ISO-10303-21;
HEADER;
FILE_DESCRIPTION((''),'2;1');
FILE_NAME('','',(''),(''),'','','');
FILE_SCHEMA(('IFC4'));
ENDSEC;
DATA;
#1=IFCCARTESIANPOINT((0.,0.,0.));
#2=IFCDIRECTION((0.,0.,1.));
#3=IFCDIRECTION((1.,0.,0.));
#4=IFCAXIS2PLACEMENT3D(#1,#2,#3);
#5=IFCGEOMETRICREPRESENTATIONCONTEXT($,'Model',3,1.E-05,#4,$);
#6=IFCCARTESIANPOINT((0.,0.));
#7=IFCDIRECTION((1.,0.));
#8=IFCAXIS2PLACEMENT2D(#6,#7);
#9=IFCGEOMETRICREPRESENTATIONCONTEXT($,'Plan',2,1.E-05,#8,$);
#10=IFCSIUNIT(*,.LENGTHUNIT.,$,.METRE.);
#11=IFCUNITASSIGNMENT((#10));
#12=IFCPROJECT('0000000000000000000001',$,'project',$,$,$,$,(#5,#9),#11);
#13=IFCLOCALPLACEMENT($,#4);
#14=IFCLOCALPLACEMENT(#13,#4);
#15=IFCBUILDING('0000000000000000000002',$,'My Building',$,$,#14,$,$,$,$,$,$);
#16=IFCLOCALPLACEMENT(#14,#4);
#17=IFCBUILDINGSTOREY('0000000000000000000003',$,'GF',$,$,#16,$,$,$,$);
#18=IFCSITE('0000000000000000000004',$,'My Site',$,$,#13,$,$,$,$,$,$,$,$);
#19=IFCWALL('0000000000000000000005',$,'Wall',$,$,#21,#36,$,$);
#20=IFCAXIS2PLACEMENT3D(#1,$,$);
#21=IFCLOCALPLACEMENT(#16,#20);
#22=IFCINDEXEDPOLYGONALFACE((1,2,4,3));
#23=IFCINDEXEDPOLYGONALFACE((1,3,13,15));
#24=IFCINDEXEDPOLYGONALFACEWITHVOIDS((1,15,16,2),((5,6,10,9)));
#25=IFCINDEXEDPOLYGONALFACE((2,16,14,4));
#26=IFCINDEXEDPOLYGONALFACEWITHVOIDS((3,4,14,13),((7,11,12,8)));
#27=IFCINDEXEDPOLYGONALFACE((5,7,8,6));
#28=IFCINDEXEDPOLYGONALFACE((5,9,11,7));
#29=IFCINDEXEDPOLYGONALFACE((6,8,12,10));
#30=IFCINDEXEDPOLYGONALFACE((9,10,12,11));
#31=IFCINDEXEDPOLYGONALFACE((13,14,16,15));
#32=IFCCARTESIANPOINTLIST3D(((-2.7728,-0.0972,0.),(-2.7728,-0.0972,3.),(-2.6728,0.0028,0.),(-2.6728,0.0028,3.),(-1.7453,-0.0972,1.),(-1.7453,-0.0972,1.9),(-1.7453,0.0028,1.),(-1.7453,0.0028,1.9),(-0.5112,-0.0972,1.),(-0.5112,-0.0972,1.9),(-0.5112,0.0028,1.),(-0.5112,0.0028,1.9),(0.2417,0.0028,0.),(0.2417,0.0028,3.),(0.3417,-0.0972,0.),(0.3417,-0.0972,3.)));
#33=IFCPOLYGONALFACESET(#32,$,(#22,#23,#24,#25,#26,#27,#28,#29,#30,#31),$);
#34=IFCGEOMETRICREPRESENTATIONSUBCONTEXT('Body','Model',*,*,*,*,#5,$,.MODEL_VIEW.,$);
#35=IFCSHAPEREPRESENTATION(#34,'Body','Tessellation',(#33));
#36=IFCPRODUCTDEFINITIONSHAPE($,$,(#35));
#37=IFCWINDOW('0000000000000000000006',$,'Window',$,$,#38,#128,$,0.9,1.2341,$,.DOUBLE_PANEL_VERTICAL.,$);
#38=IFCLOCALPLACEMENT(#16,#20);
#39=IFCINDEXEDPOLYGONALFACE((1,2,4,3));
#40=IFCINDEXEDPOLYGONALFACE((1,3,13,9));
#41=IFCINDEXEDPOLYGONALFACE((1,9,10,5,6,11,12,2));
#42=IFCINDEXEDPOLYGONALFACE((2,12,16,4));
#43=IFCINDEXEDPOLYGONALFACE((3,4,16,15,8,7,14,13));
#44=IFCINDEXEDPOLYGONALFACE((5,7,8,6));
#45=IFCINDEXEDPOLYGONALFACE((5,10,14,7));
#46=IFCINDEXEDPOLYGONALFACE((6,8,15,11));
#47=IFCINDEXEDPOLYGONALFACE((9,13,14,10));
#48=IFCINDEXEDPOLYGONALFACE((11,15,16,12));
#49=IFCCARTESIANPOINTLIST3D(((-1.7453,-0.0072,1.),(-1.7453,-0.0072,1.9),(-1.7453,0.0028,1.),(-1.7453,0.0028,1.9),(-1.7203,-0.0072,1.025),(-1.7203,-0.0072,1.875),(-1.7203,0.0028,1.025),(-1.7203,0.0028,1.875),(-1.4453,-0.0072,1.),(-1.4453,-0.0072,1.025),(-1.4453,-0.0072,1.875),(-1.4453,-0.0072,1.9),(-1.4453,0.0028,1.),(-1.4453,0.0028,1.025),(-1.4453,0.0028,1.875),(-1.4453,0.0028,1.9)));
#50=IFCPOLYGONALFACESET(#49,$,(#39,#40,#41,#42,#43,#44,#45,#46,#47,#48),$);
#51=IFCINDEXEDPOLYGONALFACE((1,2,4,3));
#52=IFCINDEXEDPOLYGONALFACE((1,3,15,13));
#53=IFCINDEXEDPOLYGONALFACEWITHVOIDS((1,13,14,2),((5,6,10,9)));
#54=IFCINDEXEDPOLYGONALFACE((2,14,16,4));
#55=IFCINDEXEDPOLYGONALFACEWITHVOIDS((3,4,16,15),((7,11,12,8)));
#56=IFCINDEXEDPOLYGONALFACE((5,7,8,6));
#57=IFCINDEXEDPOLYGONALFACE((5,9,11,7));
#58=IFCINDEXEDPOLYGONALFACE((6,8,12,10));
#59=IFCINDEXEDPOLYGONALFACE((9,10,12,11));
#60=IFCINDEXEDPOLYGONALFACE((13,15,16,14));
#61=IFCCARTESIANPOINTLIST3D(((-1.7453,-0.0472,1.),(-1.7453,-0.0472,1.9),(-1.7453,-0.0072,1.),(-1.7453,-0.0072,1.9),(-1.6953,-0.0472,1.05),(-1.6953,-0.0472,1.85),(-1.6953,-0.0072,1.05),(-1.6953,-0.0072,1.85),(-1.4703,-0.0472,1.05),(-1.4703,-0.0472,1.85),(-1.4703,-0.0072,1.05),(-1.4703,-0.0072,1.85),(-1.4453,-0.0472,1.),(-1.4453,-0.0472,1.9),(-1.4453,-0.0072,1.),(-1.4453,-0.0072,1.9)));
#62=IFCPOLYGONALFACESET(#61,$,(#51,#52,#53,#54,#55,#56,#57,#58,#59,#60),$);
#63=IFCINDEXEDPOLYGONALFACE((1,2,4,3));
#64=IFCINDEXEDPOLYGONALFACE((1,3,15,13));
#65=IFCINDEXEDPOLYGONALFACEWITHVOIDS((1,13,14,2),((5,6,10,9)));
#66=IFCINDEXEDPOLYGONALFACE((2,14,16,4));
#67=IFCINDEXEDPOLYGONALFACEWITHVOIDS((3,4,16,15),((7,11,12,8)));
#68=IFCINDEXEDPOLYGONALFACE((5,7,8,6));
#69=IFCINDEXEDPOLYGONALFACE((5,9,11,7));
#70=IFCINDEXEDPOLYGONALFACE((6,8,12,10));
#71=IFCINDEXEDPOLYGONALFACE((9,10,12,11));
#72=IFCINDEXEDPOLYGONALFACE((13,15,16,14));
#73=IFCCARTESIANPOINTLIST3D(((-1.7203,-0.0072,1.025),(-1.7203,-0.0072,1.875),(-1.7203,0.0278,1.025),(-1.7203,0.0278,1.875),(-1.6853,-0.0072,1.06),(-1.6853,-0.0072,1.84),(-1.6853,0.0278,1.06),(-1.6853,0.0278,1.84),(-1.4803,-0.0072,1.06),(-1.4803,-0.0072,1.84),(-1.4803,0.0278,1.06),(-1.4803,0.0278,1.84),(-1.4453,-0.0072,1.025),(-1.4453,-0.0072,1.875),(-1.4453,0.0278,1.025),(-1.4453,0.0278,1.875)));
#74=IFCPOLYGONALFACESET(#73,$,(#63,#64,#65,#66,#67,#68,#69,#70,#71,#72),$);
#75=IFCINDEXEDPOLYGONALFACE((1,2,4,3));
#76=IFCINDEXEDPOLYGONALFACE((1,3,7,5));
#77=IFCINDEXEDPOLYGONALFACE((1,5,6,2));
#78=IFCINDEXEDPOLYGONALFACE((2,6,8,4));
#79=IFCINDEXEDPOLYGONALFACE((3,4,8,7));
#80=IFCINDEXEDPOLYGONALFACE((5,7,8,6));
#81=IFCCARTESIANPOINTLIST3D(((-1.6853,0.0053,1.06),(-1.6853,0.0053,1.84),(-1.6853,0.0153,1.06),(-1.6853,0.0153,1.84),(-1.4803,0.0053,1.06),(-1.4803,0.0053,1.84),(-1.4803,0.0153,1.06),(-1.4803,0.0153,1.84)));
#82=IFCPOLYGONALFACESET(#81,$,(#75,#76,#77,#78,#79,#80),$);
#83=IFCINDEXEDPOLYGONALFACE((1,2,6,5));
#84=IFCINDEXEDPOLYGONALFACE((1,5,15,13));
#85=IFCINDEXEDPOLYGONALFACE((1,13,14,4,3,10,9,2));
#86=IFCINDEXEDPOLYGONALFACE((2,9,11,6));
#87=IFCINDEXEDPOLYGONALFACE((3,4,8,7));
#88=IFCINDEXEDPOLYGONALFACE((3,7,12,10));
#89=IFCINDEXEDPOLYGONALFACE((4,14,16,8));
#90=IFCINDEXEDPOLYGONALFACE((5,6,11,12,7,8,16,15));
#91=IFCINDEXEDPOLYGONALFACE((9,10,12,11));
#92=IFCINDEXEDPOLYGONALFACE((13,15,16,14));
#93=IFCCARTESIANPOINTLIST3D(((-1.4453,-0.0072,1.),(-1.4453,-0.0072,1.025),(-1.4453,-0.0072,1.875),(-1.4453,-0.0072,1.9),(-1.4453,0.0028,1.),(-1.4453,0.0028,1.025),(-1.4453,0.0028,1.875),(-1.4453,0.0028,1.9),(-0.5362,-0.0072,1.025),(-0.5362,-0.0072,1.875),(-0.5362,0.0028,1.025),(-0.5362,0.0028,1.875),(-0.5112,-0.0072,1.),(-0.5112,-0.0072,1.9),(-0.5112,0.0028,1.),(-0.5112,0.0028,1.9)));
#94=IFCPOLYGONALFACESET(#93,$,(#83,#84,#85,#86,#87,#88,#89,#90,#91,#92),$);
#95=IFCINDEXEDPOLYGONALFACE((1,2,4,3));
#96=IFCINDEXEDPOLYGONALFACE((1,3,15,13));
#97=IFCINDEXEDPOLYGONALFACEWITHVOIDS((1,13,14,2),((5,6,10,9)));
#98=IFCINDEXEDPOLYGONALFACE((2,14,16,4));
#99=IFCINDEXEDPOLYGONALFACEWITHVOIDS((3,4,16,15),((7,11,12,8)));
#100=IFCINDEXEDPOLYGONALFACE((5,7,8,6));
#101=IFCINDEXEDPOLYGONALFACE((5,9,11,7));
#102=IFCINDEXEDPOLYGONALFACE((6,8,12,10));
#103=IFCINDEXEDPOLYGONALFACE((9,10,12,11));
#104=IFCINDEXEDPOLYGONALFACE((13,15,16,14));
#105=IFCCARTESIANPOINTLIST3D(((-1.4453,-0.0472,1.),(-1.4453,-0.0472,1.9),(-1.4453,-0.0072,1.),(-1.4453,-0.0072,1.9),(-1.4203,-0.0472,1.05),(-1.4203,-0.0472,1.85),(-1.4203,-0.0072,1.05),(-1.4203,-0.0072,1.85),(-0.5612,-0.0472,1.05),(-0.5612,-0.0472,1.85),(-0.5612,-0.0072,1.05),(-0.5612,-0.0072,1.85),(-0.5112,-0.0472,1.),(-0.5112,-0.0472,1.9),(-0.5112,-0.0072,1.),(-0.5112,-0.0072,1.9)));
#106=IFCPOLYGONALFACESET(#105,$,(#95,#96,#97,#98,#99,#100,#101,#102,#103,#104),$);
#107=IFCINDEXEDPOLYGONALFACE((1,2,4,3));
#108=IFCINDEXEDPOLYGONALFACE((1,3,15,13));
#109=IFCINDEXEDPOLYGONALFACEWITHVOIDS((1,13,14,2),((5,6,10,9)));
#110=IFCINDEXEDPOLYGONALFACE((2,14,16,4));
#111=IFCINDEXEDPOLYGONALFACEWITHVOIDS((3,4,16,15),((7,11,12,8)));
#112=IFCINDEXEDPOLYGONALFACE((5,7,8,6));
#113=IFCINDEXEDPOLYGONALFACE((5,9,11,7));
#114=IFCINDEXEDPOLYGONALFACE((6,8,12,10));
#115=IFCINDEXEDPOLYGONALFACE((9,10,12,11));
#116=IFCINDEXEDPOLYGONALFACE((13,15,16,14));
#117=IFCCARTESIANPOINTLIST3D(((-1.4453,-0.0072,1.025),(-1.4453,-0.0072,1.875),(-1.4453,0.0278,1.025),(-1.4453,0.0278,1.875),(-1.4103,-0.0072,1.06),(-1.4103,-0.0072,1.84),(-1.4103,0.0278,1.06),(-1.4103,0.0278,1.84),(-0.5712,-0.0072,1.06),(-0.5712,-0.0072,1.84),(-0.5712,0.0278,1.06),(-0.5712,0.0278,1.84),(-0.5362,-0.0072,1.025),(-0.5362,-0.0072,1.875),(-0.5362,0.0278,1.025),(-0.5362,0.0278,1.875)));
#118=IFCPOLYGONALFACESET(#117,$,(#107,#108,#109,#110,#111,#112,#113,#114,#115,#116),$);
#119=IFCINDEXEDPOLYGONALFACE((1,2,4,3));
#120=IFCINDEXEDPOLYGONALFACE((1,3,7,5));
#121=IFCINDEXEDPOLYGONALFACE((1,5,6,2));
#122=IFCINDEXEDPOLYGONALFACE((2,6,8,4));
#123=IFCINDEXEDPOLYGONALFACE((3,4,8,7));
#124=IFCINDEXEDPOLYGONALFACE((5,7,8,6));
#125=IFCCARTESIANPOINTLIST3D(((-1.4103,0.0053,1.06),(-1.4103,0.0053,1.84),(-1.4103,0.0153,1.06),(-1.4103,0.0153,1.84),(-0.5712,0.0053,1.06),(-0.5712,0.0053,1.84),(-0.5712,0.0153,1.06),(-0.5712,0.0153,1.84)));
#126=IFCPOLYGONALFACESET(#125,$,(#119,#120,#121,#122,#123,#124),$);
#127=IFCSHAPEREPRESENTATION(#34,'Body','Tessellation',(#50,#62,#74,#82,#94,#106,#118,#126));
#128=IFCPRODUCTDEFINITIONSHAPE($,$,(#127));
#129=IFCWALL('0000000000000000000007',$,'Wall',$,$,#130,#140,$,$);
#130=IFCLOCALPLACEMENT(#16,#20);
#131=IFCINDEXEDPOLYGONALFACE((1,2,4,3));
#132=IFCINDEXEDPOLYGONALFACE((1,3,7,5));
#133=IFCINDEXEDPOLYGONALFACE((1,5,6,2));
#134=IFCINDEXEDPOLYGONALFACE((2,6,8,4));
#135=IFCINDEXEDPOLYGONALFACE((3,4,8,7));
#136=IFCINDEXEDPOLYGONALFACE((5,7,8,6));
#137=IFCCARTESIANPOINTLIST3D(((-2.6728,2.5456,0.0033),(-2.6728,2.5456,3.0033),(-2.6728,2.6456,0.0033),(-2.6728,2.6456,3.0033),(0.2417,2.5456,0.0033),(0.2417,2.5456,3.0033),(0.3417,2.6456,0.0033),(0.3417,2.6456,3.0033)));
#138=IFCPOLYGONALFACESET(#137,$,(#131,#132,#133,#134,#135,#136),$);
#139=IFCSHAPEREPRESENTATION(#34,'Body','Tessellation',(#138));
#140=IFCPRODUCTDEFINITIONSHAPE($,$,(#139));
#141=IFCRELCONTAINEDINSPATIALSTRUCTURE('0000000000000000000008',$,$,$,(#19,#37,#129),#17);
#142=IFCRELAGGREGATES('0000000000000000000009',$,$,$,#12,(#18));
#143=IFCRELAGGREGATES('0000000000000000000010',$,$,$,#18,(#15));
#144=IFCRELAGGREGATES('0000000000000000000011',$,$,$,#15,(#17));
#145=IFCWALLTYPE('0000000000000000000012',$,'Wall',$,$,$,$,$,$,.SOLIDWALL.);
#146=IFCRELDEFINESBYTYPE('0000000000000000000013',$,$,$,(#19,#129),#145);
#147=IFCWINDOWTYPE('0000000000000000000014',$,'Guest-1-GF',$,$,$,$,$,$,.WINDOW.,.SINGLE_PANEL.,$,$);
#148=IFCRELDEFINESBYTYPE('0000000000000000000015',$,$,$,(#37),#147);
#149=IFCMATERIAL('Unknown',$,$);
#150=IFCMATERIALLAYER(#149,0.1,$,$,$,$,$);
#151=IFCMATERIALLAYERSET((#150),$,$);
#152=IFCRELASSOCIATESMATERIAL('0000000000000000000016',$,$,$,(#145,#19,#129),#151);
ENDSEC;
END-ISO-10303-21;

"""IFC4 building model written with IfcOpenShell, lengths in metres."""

from ifc_helpers import new_model, entity, si_unit, frame, origin_with_axes, origin_2d_with_axis, place, context, subcontext, project, spatial, line, indexed_curve, outline, extrude, shape, source, transform, mapped, material, layer, layer_set, layer_usage, type_object, type_shapes, element, fill, save


model = new_model("IFC4")

# Units and contexts
model_context = context("Model", 3, precision=1e-05, world=origin_with_axes())
plan_context = context("Plan", 2, precision=1e-05, world=origin_2d_with_axis())
body_context_1 = subcontext(model_context, "Body", "Model", "MODEL_VIEW")
body_context_2 = subcontext(plan_context, "Body", "Plan", "PLAN_VIEW")
ifc_project = project(units=[si_unit("LENGTHUNIT", "METRE")], contexts=[model_context, plan_context])

# Site, building, storey
site_placement = place(None, origin_with_axes())
site = spatial("IfcSite", under=ifc_project, at=site_placement, Name="My Site")
building_placement = place(site_placement, origin_with_axes())
building = spatial("IfcBuilding", under=site, at=building_placement, Name="My Building")
storey_placement = place(building_placement, origin_with_axes())
storey = spatial("IfcBuildingStorey", under=building, at=storey_placement, Name="GF")

# Shared definitions
ifc_material = material(Name="Unknown")

# Shared definitions
ifc_layer_1 = layer(ifc_material, 0.1)
ifc_layer_set_1 = layer_set([ifc_layer_1])
wall_type = type_object("IfcWallType", Name="Wall", PredefinedType="SOLIDWALL", material=ifc_layer_set_1)

# Wall, opening, window
ifc_layer_usage_1 = layer_usage(ifc_layer_set_1, "AXIS2", "POSITIVE", 0.0)
wall_1_placement = place(storey_placement, frame((-2.7728, -0.0972, 0.0), z_axis=(0.0, 0.0, 1.0), x_axis=(1.0, 0.0, 0.0)))
wall_1 = element("IfcWall", 1, at=wall_1_placement, inside=storey, type_object=wall_type, material=ifc_layer_usage_1, Name="Wall", context=body_context_1, shape_type="SweptSolid", body=[
    extrude(outline(indexed_curve([(0.0, 0.0), (0.1, 0.1), (3.0145, 0.1), (3.1145, 0.0)], segments=[line(1, 2, 3, 4, 1)])), origin_with_axes(), (0.0, 0.0, 1.0), 3.0),
])
shared_shape_1 = source(origin_with_axes(), body_context_1, "Body", "SweptSolid", [
    extrude(outline(indexed_curve([(0.0, 0.0), (1.2341, 0.0), (1.2341, 0.9), (0.0, 0.9)], segments=[line(1, 2, 3, 4, 1)])), frame((0.0, -0.6, 0.0), z_axis=(0.0, -1.0, 0.0), x_axis=(1.0, 0.0, 0.0)), (0.0, 0.0, -1.0), 1.2),
])
opening_1_placement = place(wall_1_placement, frame((1.0275, 0.0, 1.0), z_axis=(0.0, 0.0, 1.0), x_axis=(1.0, 0.0, 0.0)))
opening_1 = element("IfcOpeningElement", 2, at=opening_1_placement, cuts=wall_1, PredefinedType="OPENING", context=body_context_1, shape_type="MappedRepresentation", body=[
    mapped(shared_shape_1, transform((0.0, 0.0, 0.0), x_axis=(1.0, 0.0, 0.0), y_axis=(0.0, 1.0, 0.0), z_axis=(0.0, 0.0, 1.0), scale=1.0)),
])
window_type_1 = type_object("IfcWindowType", Name="Guest-1-GF", PartitioningType="SINGLE_PANEL", PredefinedType="WINDOW")
shared_shape_2 = source(origin_with_axes(), body_context_1, "Body", "SweptSolid", [
    extrude(outline(indexed_curve([(0.3, 0.0), (0.0, 0.0), (0.0, 0.9), (0.3, 0.9), (0.3, 0.875), (0.025, 0.875), (0.025, 0.025), (0.3, 0.025)], segments=[line(1, 2, 3, 4, 5, 6, 7, 8, 1)])), frame((0.0, 0.09, 0.0), z_axis=(0.0, -1.0, 0.0), x_axis=(1.0, 0.0, 0.0)), (0.0, 0.0, -1.0), 0.01),
    extrude(outline(indexed_curve([(0.0, 0.0), (0.3, 0.0), (0.3, 0.9), (0.0, 0.9)], segments=[line(1, 2, 3, 4, 1)]), holes=[indexed_curve([(0.05, 0.05), (0.275, 0.05), (0.275, 0.85), (0.05, 0.85)], segments=[line(1, 2, 3, 4, 1)])]), frame((0.0, 0.05, 0.0), z_axis=(0.0, -1.0, 0.0), x_axis=(1.0, 0.0, 0.0)), (0.0, 0.0, -1.0), 0.04),
    extrude(outline(indexed_curve([(0.0, 0.0), (0.275, 0.0), (0.275, 0.85), (0.0, 0.85)], segments=[line(1, 2, 3, 4, 1)]), holes=[indexed_curve([(0.035, 0.035), (0.24, 0.035), (0.24, 0.815), (0.035, 0.815)], segments=[line(1, 2, 3, 4, 1)])]), frame((0.025, 0.09, 0.025), z_axis=(0.0, -1.0, 0.0), x_axis=(1.0, 0.0, 0.0)), (0.0, 0.0, -1.0), 0.035),
    extrude(outline(indexed_curve([(0.035, 0.035), (0.24, 0.035), (0.24, 0.815), (0.035, 0.815)], segments=[line(1, 2, 3, 4, 1)])), frame((0.025, 0.1025, 0.025), z_axis=(0.0, -1.0, 0.0), x_axis=(1.0, 0.0, 0.0)), (0.0, 0.0, -1.0), 0.01),
    extrude(outline(indexed_curve([(0.0, 0.9), (0.9341, 0.9), (0.9341, 0.0), (0.0, 0.0), (0.0, 0.025), (0.9091, 0.025), (0.9091, 0.875), (0.0, 0.875)], segments=[line(1, 2, 3, 4, 5, 6, 7, 8, 1)])), frame((0.3, 0.09, 0.0), z_axis=(0.0, -1.0, 0.0), x_axis=(1.0, 0.0, 0.0)), (0.0, 0.0, -1.0), 0.01),
    extrude(outline(indexed_curve([(0.0, 0.0), (0.9341, 0.0), (0.9341, 0.9), (0.0, 0.9)], segments=[line(1, 2, 3, 4, 1)]), holes=[indexed_curve([(0.025, 0.05), (0.8841, 0.05), (0.8841, 0.85), (0.025, 0.85)], segments=[line(1, 2, 3, 4, 1)])]), frame((0.3, 0.05, 0.0), z_axis=(0.0, -1.0, 0.0), x_axis=(1.0, 0.0, 0.0)), (0.0, 0.0, -1.0), 0.04),
    extrude(outline(indexed_curve([(0.0, 0.0), (0.9091, 0.0), (0.9091, 0.85), (0.0, 0.85)], segments=[line(1, 2, 3, 4, 1)]), holes=[indexed_curve([(0.035, 0.035), (0.8741, 0.035), (0.8741, 0.815), (0.035, 0.815)], segments=[line(1, 2, 3, 4, 1)])]), frame((0.3, 0.09, 0.025), z_axis=(0.0, -1.0, 0.0), x_axis=(1.0, 0.0, 0.0)), (0.0, 0.0, -1.0), 0.035),
    extrude(outline(indexed_curve([(0.035, 0.035), (0.8741, 0.035), (0.8741, 0.815), (0.035, 0.815)], segments=[line(1, 2, 3, 4, 1)])), frame((0.3, 0.1025, 0.025), z_axis=(0.0, -1.0, 0.0), x_axis=(1.0, 0.0, 0.0)), (0.0, 0.0, -1.0), 0.01),
])
shared_shape_3 = source(origin_with_axes(), body_context_2, "Body", "Curve2D", [
    entity("IfcIndexedPolyCurve", entity("IfcCartesianPointList2D", [[0.05, 0.05], [0.275, 0.05]])),
    entity("IfcIndexedPolyCurve", entity("IfcCartesianPointList2D", [[0.0, 0.1], [0.025, 0.1], [0.025, 0.09], [0.05, 0.09], [0.05, 0.05], [0.0, 0.05]]), [entity("IfcLineIndex", [1, 2, 3, 4, 5, 6, 1])]),
    entity("IfcIndexedPolyCurve", entity("IfcCartesianPointList2D", [[0.3, 0.1], [0.3, 0.1], [0.3, 0.09], [0.275, 0.09], [0.275, 0.05], [0.3, 0.05]])),
    entity("IfcIndexedPolyCurve", entity("IfcCartesianPointList2D", [[0.025, 0.09], [0.06, 0.09], [0.06, 0.125], [0.025, 0.125]]), [entity("IfcLineIndex", [1, 2, 3, 4, 1])]),
    entity("IfcIndexedPolyCurve", entity("IfcCartesianPointList2D", [[0.3, 0.09], [0.265, 0.09], [0.265, 0.125], [0.3, 0.125]]), [entity("IfcLineIndex", [1, 2, 3, 4, 1])]),
    entity("IfcIndexedPolyCurve", entity("IfcCartesianPointList2D", [[0.06, 0.09], [0.265, 0.09]])),
    entity("IfcIndexedPolyCurve", entity("IfcCartesianPointList2D", [[0.06, 0.125], [0.265, 0.125]])),
    entity("IfcIndexedPolyCurve", entity("IfcCartesianPointList2D", [[0.06, 0.1075], [0.265, 0.1075]])),
    entity("IfcIndexedPolyCurve", entity("IfcCartesianPointList2D", [[0.325, 0.05], [1.1841, 0.05]])),
    entity("IfcIndexedPolyCurve", entity("IfcCartesianPointList2D", [[0.3, 0.1], [0.3, 0.1], [0.3, 0.09], [0.325, 0.09], [0.325, 0.05], [0.3, 0.05]])),
    entity("IfcIndexedPolyCurve", entity("IfcCartesianPointList2D", [[1.2341, 0.1], [1.2091, 0.1], [1.2091, 0.09], [1.1841, 0.09], [1.1841, 0.05], [1.2341, 0.05]]), [entity("IfcLineIndex", [1, 2, 3, 4, 5, 6, 1])]),
    entity("IfcIndexedPolyCurve", entity("IfcCartesianPointList2D", [[0.3, 0.09], [0.335, 0.09], [0.335, 0.125], [0.3, 0.125]]), [entity("IfcLineIndex", [1, 2, 3, 4, 1])]),
    entity("IfcIndexedPolyCurve", entity("IfcCartesianPointList2D", [[1.2091, 0.09], [1.1741, 0.09], [1.1741, 0.125], [1.2091, 0.125]]), [entity("IfcLineIndex", [1, 2, 3, 4, 1])]),
    entity("IfcIndexedPolyCurve", entity("IfcCartesianPointList2D", [[0.335, 0.09], [1.1741, 0.09]])),
    entity("IfcIndexedPolyCurve", entity("IfcCartesianPointList2D", [[0.335, 0.125], [1.1741, 0.125]])),
    entity("IfcIndexedPolyCurve", entity("IfcCartesianPointList2D", [[0.335, 0.1075], [1.1741, 0.1075]])),
])
type_shapes(window_type_1, [shared_shape_2, shared_shape_3])
window_1_placement = place(opening_1_placement, frame((0.0, 0.0, 0.0), z_axis=(0.0, 0.0, 1.0), x_axis=(1.0, 0.0, 0.0)))
window_1 = element("IfcWindow", 3, at=window_1_placement, inside=storey, type_object=window_type_1, Name="Window", OverallHeight=0.9, OverallWidth=1.2341, PartitioningType="DOUBLE_PANEL_VERTICAL", shapes=[
    shape(body_context_1, "Body", "MappedRepresentation", [mapped(shared_shape_2, transform((0.0, 0.0, 0.0), x_axis=(1.0, 0.0, 0.0), y_axis=(0.0, 1.0, 0.0), z_axis=(0.0, 0.0, 1.0), scale=1.0))]),
    shape(body_context_2, "Body", "MappedRepresentation", [mapped(shared_shape_3, transform((0.0, 0.0, 0.0), x_axis=(1.0, 0.0, 0.0), y_axis=(0.0, 1.0, 0.0), z_axis=(0.0, 0.0, 1.0), scale=1.0))]),
])
fill(opening_1, window_1)

# Wall
ifc_layer_usage_2 = layer_usage(ifc_layer_set_1, "AXIS2", "POSITIVE", 0.0)
wall_2_placement = place(storey_placement, frame((-2.7728, 2.5456, 0.0033), z_axis=(0.0, 0.0, 1.0), x_axis=(1.0, 0.0, 0.0)))
element("IfcWall", 4, at=wall_2_placement, inside=storey, type_object=wall_type, material=ifc_layer_usage_2, Name="Wall", context=body_context_1, shape_type="SweptSolid", body=[
    extrude(outline(indexed_curve([(0.1, 0.0), (0.1, 0.1), (3.1145, 0.1), (3.0145, 0.0)], segments=[line(1, 2, 3, 4, 1)])), origin_with_axes(), (0.0, 0.0, 1.0), 3.0),
])

save(model, "model.ifc")
